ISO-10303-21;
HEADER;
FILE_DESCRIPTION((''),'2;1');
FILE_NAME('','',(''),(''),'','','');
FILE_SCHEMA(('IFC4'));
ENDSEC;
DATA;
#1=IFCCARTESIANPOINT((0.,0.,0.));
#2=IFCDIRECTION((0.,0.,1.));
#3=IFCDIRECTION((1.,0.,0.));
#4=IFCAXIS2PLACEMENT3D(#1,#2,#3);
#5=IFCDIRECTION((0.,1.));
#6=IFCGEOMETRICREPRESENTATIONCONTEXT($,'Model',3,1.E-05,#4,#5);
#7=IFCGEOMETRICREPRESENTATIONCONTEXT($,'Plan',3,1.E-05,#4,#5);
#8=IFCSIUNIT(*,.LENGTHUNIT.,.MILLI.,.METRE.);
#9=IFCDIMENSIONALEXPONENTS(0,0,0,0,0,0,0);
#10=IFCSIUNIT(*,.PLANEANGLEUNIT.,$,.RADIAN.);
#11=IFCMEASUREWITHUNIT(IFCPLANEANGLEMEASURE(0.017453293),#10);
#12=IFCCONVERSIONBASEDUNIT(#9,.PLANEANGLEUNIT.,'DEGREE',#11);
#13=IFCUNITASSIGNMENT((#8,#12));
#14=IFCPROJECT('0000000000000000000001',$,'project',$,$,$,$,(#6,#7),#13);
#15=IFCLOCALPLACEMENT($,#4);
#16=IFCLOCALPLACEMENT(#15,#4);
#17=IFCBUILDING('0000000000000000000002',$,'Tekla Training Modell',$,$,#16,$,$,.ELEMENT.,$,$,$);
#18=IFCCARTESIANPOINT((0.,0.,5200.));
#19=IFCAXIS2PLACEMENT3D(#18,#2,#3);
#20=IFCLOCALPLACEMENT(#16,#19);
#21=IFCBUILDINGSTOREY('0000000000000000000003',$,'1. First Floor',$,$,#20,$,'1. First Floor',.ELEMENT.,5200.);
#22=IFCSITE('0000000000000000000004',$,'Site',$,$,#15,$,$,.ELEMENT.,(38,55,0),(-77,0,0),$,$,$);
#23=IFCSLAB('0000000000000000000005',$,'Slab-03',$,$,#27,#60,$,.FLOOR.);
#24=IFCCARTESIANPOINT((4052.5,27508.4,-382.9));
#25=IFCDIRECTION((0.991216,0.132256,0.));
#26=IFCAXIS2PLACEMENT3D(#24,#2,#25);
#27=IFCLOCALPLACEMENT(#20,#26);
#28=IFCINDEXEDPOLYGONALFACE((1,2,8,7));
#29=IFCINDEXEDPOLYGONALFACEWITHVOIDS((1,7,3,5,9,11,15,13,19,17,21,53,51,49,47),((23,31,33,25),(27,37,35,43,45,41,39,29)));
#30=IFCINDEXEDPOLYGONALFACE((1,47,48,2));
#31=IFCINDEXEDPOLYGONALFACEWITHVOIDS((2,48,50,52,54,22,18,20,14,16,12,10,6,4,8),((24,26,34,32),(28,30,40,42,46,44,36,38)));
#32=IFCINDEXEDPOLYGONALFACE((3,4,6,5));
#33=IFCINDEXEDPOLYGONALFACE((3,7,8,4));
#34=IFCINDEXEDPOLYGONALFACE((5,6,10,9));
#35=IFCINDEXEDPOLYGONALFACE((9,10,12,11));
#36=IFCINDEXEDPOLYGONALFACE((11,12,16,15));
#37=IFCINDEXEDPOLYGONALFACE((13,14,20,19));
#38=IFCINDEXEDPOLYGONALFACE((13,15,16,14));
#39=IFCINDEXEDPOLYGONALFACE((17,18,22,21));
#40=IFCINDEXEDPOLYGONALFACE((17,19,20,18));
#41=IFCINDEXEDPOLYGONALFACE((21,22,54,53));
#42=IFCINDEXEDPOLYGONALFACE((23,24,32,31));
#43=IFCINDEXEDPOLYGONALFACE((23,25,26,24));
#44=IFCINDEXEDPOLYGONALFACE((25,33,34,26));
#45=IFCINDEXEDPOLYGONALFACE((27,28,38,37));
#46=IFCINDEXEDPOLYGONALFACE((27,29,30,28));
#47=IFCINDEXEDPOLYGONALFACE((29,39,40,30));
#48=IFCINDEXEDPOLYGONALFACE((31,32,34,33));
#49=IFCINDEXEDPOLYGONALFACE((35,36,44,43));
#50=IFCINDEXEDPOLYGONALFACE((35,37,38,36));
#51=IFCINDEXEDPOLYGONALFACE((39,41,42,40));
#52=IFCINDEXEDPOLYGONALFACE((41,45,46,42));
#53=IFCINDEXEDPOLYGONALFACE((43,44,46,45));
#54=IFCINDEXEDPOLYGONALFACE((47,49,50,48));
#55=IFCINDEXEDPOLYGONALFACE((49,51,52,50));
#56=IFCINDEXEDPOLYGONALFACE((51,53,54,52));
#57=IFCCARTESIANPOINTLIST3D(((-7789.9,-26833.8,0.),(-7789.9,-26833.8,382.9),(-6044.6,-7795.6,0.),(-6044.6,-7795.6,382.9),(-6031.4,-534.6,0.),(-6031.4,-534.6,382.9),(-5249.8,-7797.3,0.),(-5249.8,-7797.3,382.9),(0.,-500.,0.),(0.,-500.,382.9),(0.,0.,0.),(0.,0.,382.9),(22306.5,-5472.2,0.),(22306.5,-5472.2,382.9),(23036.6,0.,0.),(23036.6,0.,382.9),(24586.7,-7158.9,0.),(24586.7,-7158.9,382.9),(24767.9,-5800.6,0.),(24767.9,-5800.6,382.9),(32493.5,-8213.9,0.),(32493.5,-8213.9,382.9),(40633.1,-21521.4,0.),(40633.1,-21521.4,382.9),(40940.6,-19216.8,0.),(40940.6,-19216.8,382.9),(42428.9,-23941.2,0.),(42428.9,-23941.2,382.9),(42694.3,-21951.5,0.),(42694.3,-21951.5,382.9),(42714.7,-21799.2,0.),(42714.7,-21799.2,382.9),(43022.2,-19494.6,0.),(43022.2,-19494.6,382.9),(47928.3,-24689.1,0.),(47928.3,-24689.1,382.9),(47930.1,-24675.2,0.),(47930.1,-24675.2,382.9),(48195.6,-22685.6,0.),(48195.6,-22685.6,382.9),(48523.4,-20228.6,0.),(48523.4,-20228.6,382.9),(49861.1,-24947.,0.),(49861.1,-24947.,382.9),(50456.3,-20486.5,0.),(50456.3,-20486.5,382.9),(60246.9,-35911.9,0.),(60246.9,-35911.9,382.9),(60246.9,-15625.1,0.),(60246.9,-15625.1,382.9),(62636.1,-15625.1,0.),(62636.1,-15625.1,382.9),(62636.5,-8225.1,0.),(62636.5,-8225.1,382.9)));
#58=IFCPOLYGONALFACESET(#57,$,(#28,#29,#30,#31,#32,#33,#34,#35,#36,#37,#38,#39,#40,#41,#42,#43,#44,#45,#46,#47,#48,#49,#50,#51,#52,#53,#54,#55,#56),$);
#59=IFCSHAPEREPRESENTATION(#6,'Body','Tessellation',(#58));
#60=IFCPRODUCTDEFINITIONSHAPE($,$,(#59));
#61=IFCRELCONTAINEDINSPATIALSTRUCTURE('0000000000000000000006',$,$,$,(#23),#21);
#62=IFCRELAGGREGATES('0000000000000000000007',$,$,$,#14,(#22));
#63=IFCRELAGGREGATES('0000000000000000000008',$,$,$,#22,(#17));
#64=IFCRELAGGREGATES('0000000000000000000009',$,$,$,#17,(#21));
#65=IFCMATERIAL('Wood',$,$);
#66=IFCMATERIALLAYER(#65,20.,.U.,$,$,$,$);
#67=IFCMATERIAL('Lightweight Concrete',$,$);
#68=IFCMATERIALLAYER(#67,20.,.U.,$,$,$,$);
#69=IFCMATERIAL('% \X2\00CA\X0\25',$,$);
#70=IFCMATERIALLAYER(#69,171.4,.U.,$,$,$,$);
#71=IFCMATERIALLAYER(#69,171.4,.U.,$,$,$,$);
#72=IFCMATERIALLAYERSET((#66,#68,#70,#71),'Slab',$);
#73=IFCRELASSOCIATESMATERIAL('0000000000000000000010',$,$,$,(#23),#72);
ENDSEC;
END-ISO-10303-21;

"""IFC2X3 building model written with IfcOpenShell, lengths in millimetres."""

from ifc_helpers import new_model, entity, si_unit, converted_unit, direction, frame, origin_with_axes, place, context, project, spatial, polyline, outline, extrude, material, layer, layer_set, layer_usage, element, save


model = new_model("IFC2X3")

# Units and contexts
model_context = context("Model", 3, precision=1e-05, world=origin_with_axes(), true_north=direction((0.0, 1.0)))
plan_context = context("Plan", 3, precision=1e-05, world=origin_with_axes(), true_north=direction((0.0, 1.0)))
ifc_project = project(units=[si_unit("LENGTHUNIT", "METRE", prefix="MILLI"), converted_unit("PLANEANGLEUNIT", "DEGREE", entity("IfcPlaneAngleMeasure", 0.017453293), si_unit("PLANEANGLEUNIT", "RADIAN"), dimensions=[0, 0, 0, 0, 0, 0, 0])], contexts=[model_context, plan_context])

# Site, building, storey
site_placement = place(None, origin_with_axes())
site = spatial("IfcSite", under=ifc_project, at=site_placement, Name="Site", CompositionType="ELEMENT", RefLatitude=(38, 55, 0), RefLongitude=(-77, 0, 0))
building_placement = place(site_placement, origin_with_axes())
building = spatial("IfcBuilding", under=site, at=building_placement, Name="Tekla Training Modell", CompositionType="ELEMENT")
storey_placement = place(building_placement, frame((0.0, 0.0, 5200.0), z_axis=(0.0, 0.0, 1.0), x_axis=(1.0, 0.0, 0.0)))
storey = spatial("IfcBuildingStorey", under=building, at=storey_placement, Name="1. First Floor", LongName="1. First Floor", CompositionType="ELEMENT", Elevation=5200.0)

# Slab, openings
ifc_material_1 = material(Name="Wood")
ifc_layer_1 = layer(ifc_material_1, 20.0, ventilated="UNKNOWN")
ifc_material_2 = material(Name="Lightweight Concrete")
ifc_layer_2 = layer(ifc_material_2, 20.0, ventilated="UNKNOWN")
ifc_material_3 = material(Name="% Ê25")
ifc_layer_3 = layer(ifc_material_3, 171.4, ventilated="UNKNOWN")
ifc_layer_4 = layer(ifc_material_3, 171.4, ventilated="UNKNOWN")
ifc_layer_set_1 = layer_set([ifc_layer_1, ifc_layer_2, ifc_layer_3, ifc_layer_4], Name="Slab")
ifc_layer_usage_1 = layer_usage(ifc_layer_set_1, "AXIS3", "NEGATIVE", 382.9)
slab_placement = place(storey_placement, frame((4052.5, 27508.4, -382.9), z_axis=(0.0, 0.0, 1.0), x_axis=(0.991216, 0.132256, 0.0)))
slab = element("IfcSlab", 1, at=slab_placement, inside=storey, material=ifc_layer_usage_1, Name="Slab-03", PredefinedType="FLOOR", context=model_context, shape_type="SweptSolid", body=[
    extrude(outline(polyline([(0.0, 0.0), (23036.6, 0.0), (22306.5, -5472.2), (24767.9, -5800.6), (24586.7, -7158.9), (32493.5, -8213.9), (62636.5, -8225.1), (62636.1, -15625.1), (60246.9, -15625.1), (60246.9, -35911.9), (-7789.9, -26833.8), (-5249.8, -7797.3), (-6044.6, -7795.6), (-6031.4, -534.6), (0.0, -500.0), (0.0, 0.0)])), origin_with_axes(), (0.0, 0.0, 1.0), 382.9),
])
opening_1_placement = place(slab_placement, origin_with_axes())
element("IfcOpeningElement", 2, at=opening_1_placement, cuts=slab, context=model_context, shape_type="SweptSolid", body=[
    extrude(outline(polyline([(48523.4, -20228.6), (50456.3, -20486.5), (49861.1, -24947.0), (47928.3, -24689.1), (47930.1, -24675.2), (42428.9, -23941.2), (42694.3, -21951.5), (48195.6, -22685.6), (48523.4, -20228.6)])), origin_with_axes(), (0.0, 0.0, 1.0), 382.9),
])
opening_2_placement = place(slab_placement, origin_with_axes())
element("IfcOpeningElement", 3, at=opening_2_placement, cuts=slab, context=model_context, shape_type="SweptSolid", body=[
    extrude(outline(polyline([(43022.2, -19494.6), (42714.7, -21799.2), (40633.1, -21521.4), (40940.6, -19216.8), (43022.2, -19494.6)])), origin_with_axes(), (0.0, 0.0, 1.0), 382.9),
])

save(model, "model.ifc")
